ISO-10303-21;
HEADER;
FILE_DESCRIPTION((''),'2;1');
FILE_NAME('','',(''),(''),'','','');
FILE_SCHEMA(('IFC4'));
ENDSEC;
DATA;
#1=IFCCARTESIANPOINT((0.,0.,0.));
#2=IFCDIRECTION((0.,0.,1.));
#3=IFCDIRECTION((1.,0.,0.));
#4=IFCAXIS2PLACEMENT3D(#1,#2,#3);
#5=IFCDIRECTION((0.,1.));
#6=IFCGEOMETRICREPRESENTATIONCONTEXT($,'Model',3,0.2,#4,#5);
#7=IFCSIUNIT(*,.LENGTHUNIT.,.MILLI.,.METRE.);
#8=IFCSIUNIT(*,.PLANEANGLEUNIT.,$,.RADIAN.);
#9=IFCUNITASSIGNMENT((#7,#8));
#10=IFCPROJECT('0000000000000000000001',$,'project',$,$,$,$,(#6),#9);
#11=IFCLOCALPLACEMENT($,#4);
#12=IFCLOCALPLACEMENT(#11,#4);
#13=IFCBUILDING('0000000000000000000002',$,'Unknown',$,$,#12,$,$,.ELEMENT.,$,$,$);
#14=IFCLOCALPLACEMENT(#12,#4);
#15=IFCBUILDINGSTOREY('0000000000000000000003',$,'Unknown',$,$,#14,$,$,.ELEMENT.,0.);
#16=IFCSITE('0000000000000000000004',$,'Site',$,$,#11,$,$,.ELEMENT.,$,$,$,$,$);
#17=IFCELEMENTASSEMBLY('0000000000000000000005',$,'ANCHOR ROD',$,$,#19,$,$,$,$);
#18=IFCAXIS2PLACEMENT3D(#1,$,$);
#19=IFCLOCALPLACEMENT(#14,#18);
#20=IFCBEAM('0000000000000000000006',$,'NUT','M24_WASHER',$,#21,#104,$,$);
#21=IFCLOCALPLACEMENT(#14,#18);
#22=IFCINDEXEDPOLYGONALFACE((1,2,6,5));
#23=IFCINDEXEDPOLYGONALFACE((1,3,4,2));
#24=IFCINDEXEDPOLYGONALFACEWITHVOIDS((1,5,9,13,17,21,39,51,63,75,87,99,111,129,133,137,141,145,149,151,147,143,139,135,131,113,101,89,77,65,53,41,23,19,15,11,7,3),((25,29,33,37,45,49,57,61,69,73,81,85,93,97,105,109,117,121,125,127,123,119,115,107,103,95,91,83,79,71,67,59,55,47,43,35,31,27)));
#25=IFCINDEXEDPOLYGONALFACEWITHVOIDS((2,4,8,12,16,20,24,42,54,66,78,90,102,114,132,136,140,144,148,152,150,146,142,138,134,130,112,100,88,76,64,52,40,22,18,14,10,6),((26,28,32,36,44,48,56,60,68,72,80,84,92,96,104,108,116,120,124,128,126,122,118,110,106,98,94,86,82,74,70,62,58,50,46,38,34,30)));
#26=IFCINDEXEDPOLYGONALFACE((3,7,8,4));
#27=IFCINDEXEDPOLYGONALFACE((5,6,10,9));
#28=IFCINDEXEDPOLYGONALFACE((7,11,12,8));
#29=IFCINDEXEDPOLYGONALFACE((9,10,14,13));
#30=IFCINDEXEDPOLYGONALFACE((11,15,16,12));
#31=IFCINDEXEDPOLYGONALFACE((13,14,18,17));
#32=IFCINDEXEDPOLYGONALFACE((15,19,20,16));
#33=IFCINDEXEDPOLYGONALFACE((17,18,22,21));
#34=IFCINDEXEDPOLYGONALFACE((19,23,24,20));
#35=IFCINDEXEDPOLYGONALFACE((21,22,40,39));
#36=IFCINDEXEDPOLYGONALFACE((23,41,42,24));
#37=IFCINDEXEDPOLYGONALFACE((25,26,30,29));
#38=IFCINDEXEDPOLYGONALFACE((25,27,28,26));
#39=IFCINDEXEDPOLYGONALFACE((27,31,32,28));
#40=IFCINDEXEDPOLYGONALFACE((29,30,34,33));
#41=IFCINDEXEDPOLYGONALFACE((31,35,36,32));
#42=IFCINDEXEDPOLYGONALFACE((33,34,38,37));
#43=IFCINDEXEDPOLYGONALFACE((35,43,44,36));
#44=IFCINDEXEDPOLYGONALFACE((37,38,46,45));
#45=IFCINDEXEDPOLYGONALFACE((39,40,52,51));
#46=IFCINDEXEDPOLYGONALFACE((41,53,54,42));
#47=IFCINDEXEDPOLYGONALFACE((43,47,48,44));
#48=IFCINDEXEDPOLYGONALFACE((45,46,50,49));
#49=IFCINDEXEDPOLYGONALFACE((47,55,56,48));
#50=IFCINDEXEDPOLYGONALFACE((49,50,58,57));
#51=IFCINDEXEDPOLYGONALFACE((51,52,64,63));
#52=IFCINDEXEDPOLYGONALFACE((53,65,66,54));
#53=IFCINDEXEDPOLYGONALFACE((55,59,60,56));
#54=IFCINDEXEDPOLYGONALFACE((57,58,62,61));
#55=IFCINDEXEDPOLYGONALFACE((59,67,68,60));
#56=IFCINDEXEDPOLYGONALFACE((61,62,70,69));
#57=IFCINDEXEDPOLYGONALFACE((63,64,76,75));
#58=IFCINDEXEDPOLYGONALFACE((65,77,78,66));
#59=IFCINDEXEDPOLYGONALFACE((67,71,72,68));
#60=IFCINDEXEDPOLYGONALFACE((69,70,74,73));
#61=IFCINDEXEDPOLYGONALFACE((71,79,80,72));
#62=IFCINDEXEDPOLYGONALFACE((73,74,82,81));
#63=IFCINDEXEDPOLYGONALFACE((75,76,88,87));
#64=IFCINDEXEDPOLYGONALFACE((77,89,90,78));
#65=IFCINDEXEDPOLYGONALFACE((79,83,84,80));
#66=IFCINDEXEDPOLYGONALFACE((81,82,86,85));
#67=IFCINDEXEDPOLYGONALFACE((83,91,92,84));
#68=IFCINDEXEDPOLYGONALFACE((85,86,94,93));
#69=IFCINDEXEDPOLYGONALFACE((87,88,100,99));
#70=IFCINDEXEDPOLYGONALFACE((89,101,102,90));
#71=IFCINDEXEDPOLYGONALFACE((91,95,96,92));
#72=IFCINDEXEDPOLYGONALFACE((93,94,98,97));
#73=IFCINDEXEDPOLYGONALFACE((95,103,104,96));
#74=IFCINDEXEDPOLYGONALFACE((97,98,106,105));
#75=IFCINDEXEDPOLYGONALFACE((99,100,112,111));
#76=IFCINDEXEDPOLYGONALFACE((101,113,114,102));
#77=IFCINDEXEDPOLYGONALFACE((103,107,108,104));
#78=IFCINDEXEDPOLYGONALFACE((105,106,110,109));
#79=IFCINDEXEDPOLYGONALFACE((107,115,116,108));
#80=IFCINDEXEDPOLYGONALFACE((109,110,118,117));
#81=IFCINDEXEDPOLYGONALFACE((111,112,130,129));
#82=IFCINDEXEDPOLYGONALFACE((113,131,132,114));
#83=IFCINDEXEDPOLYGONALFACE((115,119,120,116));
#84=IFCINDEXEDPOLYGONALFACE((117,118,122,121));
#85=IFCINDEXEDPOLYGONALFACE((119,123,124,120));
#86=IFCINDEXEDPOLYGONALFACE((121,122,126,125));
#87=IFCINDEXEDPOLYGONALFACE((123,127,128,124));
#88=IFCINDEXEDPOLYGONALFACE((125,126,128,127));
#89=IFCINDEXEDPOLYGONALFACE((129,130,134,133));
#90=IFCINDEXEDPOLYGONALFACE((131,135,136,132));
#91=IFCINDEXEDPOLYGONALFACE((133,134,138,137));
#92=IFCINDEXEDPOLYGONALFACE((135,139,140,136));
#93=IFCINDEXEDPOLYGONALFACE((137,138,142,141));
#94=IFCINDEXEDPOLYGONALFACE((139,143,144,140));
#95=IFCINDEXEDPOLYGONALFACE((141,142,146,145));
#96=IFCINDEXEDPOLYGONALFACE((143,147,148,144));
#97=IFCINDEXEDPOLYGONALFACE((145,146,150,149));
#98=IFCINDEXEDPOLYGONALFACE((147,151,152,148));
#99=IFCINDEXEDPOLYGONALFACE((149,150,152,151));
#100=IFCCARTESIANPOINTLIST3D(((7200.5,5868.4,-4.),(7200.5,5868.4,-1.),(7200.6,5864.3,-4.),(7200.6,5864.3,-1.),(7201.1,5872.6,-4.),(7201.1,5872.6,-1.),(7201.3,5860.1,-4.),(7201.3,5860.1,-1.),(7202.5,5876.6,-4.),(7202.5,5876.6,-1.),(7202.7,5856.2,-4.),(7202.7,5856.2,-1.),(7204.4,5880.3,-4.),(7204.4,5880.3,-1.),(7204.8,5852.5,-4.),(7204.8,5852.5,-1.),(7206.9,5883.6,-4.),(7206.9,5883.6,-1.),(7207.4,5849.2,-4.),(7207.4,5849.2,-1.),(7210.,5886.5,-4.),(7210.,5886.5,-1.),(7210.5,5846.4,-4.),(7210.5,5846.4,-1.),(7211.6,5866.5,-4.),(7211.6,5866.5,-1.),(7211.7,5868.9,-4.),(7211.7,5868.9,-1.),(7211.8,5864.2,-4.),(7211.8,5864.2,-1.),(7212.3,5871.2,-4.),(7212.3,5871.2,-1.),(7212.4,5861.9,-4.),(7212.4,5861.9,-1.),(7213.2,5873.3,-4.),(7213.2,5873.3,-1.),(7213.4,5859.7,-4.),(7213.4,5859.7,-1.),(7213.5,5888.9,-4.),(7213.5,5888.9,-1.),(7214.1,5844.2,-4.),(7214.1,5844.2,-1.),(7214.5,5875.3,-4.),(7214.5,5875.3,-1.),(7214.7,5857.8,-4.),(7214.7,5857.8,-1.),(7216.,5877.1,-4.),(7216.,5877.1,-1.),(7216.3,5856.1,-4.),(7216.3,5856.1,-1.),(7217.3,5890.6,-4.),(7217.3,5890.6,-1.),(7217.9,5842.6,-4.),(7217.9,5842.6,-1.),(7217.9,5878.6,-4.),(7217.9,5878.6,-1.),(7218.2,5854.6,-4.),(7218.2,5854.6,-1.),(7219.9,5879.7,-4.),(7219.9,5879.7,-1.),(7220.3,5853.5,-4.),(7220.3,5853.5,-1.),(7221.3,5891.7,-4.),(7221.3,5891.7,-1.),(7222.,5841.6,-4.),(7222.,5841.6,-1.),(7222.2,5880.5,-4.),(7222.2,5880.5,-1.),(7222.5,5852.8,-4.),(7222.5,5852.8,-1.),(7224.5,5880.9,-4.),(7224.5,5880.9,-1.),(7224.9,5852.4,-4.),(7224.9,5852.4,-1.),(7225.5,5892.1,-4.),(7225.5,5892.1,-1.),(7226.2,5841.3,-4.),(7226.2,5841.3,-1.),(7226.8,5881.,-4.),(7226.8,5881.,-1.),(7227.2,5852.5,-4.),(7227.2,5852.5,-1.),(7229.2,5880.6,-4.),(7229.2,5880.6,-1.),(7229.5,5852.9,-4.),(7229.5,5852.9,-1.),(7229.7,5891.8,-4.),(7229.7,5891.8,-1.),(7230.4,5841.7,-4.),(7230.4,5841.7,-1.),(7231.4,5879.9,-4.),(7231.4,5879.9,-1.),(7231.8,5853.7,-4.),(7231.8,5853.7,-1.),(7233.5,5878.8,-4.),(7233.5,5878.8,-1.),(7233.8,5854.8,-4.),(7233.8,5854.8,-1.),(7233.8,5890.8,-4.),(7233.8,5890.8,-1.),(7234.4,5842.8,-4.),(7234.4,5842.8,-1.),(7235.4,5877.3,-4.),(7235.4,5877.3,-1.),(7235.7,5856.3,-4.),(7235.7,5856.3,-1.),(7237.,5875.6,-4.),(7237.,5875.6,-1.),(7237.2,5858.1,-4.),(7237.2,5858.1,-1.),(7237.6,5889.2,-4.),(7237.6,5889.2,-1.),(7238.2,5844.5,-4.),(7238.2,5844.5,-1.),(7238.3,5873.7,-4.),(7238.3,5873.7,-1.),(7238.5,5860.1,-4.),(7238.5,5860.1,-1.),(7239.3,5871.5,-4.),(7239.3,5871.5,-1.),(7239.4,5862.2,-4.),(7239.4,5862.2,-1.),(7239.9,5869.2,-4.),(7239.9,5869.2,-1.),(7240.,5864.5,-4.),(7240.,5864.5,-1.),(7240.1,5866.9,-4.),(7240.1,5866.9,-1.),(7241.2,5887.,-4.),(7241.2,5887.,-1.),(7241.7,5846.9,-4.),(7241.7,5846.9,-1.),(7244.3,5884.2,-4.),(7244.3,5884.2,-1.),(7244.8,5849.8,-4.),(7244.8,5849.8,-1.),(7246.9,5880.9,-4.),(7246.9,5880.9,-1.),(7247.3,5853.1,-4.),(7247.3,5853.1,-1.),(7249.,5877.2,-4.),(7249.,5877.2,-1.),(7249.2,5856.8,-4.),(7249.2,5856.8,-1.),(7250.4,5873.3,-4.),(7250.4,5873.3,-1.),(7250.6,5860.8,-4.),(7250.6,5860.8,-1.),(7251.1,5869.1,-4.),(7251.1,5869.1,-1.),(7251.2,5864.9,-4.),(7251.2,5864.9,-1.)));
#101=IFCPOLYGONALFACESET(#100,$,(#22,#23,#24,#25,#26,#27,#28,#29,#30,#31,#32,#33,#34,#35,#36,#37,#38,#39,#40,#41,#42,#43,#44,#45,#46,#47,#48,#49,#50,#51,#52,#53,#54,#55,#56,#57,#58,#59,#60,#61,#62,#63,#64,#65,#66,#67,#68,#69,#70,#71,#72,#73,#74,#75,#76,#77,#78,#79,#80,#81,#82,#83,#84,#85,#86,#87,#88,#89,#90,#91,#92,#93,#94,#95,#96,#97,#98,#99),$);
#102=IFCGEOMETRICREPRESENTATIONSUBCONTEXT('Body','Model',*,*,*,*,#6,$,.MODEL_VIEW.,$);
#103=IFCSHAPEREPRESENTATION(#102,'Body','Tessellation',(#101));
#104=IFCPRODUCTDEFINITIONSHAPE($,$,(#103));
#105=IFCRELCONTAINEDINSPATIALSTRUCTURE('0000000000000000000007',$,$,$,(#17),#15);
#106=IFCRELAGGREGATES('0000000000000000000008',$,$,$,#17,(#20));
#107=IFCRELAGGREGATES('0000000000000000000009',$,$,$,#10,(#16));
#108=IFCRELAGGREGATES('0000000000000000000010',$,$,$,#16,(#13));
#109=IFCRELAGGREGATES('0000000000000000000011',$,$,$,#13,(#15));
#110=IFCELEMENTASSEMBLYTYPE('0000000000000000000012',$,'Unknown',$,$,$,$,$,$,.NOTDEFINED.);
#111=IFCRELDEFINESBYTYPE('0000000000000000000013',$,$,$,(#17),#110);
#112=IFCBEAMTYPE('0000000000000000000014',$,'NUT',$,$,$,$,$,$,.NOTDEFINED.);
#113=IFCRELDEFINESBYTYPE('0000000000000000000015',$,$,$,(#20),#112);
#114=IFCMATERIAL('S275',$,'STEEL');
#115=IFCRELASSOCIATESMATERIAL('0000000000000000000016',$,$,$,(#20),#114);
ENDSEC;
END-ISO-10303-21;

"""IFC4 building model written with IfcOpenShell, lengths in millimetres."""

from ifc_helpers import new_model, si_unit, direction, frame, origin_with_axes, place, context, subcontext, project, spatial, polyline, outline, extrude, material, material_profile, profile_set, profile_usage, type_object, element, aggregate, save


model = new_model("IFC4")

# Units and contexts
model_context = context("Model", 3, precision=0.2, world=origin_with_axes(), true_north=direction((0.0, 1.0)))
body_context = subcontext(model_context, "Body", "Model", "MODEL_VIEW")
ifc_project = project(units=[si_unit("LENGTHUNIT", "METRE", prefix="MILLI"), si_unit("PLANEANGLEUNIT", "RADIAN")], contexts=[model_context])

# Site, building, storey
site_placement = place(None, origin_with_axes())
site = spatial("IfcSite", under=ifc_project, at=site_placement, Name="Site", CompositionType="ELEMENT")
building_placement = place(site_placement, origin_with_axes())
building = spatial("IfcBuilding", under=site, at=building_placement, Name="Unknown", CompositionType="ELEMENT")
storey_placement = place(building_placement, origin_with_axes())
storey = spatial("IfcBuildingStorey", under=building, at=storey_placement, Name="Unknown", CompositionType="ELEMENT", Elevation=0.0)

# Element assembly, beam
element_assembly_type = type_object("IfcElementAssemblyType", Name="Unknown", PredefinedType="NOTDEFINED")
ifc_material_1 = material(Name="S275", Category="STEEL")
ifc_material_profile_1 = material_profile(ifc_material_1, outline(polyline([(25.4, 0.0), (25.1, 4.2), (24.0, 8.2), (22.3, 12.1), (20.0, 15.6), (17.2, 18.7), (13.9, 21.3), (10.2, 23.3), (6.2, 24.6), (2.1, 25.3), (-2.1, 25.3), (-6.2, 24.6), (-10.2, 23.3), (-13.9, 21.3), (-17.2, 18.7), (-20.0, 15.6), (-22.3, 12.1), (-24.0, 8.2), (-25.1, 4.2), (-25.4, 0.0), (-25.1, -4.2), (-24.0, -8.2), (-22.3, -12.1), (-20.0, -15.6), (-17.2, -18.7), (-13.9, -21.3), (-10.2, -23.3), (-6.2, -24.6), (-2.1, -25.3), (2.1, -25.3), (6.2, -24.6), (10.2, -23.3), (13.9, -21.3), (17.2, -18.7), (20.0, -15.6), (22.3, -12.1), (24.0, -8.2), (25.1, -4.2), (25.4, 0.0)]), holes=[polyline([(0.0, 14.3), (2.4, 14.1), (4.6, 13.5), (6.8, 12.6), (8.8, 11.3), (10.5, 9.7), (12.0, 7.8), (13.1, 5.7), (13.9, 3.5), (14.2, 1.2), (14.2, -1.2), (13.9, -3.5), (13.1, -5.7), (12.0, -7.8), (10.5, -9.7), (8.8, -11.3), (6.8, -12.6), (4.6, -13.5), (2.4, -14.1), (0.0, -14.3), (-2.4, -14.1), (-4.6, -13.5), (-6.8, -12.6), (-8.8, -11.3), (-10.5, -9.7), (-12.0, -7.8), (-13.1, -5.7), (-13.9, -3.5), (-14.2, -1.2), (-14.2, 1.2), (-13.9, 3.5), (-13.1, 5.7), (-12.0, 7.8), (-10.5, 9.7), (-8.8, 11.3), (-6.8, 12.6), (-4.6, 13.5), (-2.4, 14.1), (0.0, 14.3)])]), Name="M24_WASHER")
ifc_profile_set_1 = profile_set([ifc_material_profile_1])
ifc_profile_usage_1 = profile_usage(ifc_profile_set_1, cardinal=5)
beam_type_1 = type_object("IfcBeamType", Name="NUT", PredefinedType="NOTDEFINED")
assembly_1_placement = place(storey_placement, frame((7225.8, 5866.7, 39.0), z_axis=(0.154419, 0.988005, 0.0), x_axis=(0.0, 0.0, -1.0)))
assembly_1 = element("IfcElementAssembly", 1, at=assembly_1_placement, inside=storey, type_object=element_assembly_type, Name="ANCHOR ROD")
beam_1_placement = place(assembly_1_placement, frame((40.0, 0.0, 0.0), z_axis=(0.0, 0.003456, 0.999994), x_axis=(1.0, 0.0, 0.0)))
beam_1 = element("IfcBeam", 2, at=beam_1_placement, type_object=beam_type_1, material=ifc_profile_usage_1, Name="NUT", Description="M24_WASHER", context=body_context, shape_type="SolidModel", body=[
    extrude(outline(polyline([(25.4, 0.0), (25.1, 4.2), (24.0, 8.2), (22.3, 12.1), (20.0, 15.6), (17.2, 18.7), (13.9, 21.3), (10.2, 23.3), (6.2, 24.6), (2.1, 25.3), (-2.1, 25.3), (-6.2, 24.6), (-10.2, 23.3), (-13.9, 21.3), (-17.2, 18.7), (-20.0, 15.6), (-22.3, 12.1), (-24.0, 8.2), (-25.1, 4.2), (-25.4, 0.0), (-25.1, -4.2), (-24.0, -8.2), (-22.3, -12.1), (-20.0, -15.6), (-17.2, -18.7), (-13.9, -21.3), (-10.2, -23.3), (-6.2, -24.6), (-2.1, -25.3), (2.1, -25.3), (6.2, -24.6), (10.2, -23.3), (13.9, -21.3), (17.2, -18.7), (20.0, -15.6), (22.3, -12.1), (24.0, -8.2), (25.1, -4.2), (25.4, 0.0)]), holes=[polyline([(0.0, 14.3), (2.4, 14.1), (4.6, 13.5), (6.8, 12.6), (8.8, 11.3), (10.5, 9.7), (12.0, 7.8), (13.1, 5.7), (13.9, 3.5), (14.2, 1.2), (14.2, -1.2), (13.9, -3.5), (13.1, -5.7), (12.0, -7.8), (10.5, -9.7), (8.8, -11.3), (6.8, -12.6), (4.6, -13.5), (2.4, -14.1), (0.0, -14.3), (-2.4, -14.1), (-4.6, -13.5), (-6.8, -12.6), (-8.8, -11.3), (-10.5, -9.7), (-12.0, -7.8), (-13.1, -5.7), (-13.9, -3.5), (-14.2, -1.2), (-14.2, 1.2), (-13.9, 3.5), (-13.1, 5.7), (-12.0, 7.8), (-10.5, 9.7), (-8.8, 11.3), (-6.8, 12.6), (-4.6, 13.5), (-2.4, 14.1), (0.0, 14.3)])]), frame((0.0, 0.0, 0.0), z_axis=(-1.0, 0.0, 0.0), x_axis=(0.0, 0.0, 1.0)), (0.0, 0.0, -1.0), 3.0),
])

aggregate(assembly_1, [beam_1])

save(model, "model.ifc")
